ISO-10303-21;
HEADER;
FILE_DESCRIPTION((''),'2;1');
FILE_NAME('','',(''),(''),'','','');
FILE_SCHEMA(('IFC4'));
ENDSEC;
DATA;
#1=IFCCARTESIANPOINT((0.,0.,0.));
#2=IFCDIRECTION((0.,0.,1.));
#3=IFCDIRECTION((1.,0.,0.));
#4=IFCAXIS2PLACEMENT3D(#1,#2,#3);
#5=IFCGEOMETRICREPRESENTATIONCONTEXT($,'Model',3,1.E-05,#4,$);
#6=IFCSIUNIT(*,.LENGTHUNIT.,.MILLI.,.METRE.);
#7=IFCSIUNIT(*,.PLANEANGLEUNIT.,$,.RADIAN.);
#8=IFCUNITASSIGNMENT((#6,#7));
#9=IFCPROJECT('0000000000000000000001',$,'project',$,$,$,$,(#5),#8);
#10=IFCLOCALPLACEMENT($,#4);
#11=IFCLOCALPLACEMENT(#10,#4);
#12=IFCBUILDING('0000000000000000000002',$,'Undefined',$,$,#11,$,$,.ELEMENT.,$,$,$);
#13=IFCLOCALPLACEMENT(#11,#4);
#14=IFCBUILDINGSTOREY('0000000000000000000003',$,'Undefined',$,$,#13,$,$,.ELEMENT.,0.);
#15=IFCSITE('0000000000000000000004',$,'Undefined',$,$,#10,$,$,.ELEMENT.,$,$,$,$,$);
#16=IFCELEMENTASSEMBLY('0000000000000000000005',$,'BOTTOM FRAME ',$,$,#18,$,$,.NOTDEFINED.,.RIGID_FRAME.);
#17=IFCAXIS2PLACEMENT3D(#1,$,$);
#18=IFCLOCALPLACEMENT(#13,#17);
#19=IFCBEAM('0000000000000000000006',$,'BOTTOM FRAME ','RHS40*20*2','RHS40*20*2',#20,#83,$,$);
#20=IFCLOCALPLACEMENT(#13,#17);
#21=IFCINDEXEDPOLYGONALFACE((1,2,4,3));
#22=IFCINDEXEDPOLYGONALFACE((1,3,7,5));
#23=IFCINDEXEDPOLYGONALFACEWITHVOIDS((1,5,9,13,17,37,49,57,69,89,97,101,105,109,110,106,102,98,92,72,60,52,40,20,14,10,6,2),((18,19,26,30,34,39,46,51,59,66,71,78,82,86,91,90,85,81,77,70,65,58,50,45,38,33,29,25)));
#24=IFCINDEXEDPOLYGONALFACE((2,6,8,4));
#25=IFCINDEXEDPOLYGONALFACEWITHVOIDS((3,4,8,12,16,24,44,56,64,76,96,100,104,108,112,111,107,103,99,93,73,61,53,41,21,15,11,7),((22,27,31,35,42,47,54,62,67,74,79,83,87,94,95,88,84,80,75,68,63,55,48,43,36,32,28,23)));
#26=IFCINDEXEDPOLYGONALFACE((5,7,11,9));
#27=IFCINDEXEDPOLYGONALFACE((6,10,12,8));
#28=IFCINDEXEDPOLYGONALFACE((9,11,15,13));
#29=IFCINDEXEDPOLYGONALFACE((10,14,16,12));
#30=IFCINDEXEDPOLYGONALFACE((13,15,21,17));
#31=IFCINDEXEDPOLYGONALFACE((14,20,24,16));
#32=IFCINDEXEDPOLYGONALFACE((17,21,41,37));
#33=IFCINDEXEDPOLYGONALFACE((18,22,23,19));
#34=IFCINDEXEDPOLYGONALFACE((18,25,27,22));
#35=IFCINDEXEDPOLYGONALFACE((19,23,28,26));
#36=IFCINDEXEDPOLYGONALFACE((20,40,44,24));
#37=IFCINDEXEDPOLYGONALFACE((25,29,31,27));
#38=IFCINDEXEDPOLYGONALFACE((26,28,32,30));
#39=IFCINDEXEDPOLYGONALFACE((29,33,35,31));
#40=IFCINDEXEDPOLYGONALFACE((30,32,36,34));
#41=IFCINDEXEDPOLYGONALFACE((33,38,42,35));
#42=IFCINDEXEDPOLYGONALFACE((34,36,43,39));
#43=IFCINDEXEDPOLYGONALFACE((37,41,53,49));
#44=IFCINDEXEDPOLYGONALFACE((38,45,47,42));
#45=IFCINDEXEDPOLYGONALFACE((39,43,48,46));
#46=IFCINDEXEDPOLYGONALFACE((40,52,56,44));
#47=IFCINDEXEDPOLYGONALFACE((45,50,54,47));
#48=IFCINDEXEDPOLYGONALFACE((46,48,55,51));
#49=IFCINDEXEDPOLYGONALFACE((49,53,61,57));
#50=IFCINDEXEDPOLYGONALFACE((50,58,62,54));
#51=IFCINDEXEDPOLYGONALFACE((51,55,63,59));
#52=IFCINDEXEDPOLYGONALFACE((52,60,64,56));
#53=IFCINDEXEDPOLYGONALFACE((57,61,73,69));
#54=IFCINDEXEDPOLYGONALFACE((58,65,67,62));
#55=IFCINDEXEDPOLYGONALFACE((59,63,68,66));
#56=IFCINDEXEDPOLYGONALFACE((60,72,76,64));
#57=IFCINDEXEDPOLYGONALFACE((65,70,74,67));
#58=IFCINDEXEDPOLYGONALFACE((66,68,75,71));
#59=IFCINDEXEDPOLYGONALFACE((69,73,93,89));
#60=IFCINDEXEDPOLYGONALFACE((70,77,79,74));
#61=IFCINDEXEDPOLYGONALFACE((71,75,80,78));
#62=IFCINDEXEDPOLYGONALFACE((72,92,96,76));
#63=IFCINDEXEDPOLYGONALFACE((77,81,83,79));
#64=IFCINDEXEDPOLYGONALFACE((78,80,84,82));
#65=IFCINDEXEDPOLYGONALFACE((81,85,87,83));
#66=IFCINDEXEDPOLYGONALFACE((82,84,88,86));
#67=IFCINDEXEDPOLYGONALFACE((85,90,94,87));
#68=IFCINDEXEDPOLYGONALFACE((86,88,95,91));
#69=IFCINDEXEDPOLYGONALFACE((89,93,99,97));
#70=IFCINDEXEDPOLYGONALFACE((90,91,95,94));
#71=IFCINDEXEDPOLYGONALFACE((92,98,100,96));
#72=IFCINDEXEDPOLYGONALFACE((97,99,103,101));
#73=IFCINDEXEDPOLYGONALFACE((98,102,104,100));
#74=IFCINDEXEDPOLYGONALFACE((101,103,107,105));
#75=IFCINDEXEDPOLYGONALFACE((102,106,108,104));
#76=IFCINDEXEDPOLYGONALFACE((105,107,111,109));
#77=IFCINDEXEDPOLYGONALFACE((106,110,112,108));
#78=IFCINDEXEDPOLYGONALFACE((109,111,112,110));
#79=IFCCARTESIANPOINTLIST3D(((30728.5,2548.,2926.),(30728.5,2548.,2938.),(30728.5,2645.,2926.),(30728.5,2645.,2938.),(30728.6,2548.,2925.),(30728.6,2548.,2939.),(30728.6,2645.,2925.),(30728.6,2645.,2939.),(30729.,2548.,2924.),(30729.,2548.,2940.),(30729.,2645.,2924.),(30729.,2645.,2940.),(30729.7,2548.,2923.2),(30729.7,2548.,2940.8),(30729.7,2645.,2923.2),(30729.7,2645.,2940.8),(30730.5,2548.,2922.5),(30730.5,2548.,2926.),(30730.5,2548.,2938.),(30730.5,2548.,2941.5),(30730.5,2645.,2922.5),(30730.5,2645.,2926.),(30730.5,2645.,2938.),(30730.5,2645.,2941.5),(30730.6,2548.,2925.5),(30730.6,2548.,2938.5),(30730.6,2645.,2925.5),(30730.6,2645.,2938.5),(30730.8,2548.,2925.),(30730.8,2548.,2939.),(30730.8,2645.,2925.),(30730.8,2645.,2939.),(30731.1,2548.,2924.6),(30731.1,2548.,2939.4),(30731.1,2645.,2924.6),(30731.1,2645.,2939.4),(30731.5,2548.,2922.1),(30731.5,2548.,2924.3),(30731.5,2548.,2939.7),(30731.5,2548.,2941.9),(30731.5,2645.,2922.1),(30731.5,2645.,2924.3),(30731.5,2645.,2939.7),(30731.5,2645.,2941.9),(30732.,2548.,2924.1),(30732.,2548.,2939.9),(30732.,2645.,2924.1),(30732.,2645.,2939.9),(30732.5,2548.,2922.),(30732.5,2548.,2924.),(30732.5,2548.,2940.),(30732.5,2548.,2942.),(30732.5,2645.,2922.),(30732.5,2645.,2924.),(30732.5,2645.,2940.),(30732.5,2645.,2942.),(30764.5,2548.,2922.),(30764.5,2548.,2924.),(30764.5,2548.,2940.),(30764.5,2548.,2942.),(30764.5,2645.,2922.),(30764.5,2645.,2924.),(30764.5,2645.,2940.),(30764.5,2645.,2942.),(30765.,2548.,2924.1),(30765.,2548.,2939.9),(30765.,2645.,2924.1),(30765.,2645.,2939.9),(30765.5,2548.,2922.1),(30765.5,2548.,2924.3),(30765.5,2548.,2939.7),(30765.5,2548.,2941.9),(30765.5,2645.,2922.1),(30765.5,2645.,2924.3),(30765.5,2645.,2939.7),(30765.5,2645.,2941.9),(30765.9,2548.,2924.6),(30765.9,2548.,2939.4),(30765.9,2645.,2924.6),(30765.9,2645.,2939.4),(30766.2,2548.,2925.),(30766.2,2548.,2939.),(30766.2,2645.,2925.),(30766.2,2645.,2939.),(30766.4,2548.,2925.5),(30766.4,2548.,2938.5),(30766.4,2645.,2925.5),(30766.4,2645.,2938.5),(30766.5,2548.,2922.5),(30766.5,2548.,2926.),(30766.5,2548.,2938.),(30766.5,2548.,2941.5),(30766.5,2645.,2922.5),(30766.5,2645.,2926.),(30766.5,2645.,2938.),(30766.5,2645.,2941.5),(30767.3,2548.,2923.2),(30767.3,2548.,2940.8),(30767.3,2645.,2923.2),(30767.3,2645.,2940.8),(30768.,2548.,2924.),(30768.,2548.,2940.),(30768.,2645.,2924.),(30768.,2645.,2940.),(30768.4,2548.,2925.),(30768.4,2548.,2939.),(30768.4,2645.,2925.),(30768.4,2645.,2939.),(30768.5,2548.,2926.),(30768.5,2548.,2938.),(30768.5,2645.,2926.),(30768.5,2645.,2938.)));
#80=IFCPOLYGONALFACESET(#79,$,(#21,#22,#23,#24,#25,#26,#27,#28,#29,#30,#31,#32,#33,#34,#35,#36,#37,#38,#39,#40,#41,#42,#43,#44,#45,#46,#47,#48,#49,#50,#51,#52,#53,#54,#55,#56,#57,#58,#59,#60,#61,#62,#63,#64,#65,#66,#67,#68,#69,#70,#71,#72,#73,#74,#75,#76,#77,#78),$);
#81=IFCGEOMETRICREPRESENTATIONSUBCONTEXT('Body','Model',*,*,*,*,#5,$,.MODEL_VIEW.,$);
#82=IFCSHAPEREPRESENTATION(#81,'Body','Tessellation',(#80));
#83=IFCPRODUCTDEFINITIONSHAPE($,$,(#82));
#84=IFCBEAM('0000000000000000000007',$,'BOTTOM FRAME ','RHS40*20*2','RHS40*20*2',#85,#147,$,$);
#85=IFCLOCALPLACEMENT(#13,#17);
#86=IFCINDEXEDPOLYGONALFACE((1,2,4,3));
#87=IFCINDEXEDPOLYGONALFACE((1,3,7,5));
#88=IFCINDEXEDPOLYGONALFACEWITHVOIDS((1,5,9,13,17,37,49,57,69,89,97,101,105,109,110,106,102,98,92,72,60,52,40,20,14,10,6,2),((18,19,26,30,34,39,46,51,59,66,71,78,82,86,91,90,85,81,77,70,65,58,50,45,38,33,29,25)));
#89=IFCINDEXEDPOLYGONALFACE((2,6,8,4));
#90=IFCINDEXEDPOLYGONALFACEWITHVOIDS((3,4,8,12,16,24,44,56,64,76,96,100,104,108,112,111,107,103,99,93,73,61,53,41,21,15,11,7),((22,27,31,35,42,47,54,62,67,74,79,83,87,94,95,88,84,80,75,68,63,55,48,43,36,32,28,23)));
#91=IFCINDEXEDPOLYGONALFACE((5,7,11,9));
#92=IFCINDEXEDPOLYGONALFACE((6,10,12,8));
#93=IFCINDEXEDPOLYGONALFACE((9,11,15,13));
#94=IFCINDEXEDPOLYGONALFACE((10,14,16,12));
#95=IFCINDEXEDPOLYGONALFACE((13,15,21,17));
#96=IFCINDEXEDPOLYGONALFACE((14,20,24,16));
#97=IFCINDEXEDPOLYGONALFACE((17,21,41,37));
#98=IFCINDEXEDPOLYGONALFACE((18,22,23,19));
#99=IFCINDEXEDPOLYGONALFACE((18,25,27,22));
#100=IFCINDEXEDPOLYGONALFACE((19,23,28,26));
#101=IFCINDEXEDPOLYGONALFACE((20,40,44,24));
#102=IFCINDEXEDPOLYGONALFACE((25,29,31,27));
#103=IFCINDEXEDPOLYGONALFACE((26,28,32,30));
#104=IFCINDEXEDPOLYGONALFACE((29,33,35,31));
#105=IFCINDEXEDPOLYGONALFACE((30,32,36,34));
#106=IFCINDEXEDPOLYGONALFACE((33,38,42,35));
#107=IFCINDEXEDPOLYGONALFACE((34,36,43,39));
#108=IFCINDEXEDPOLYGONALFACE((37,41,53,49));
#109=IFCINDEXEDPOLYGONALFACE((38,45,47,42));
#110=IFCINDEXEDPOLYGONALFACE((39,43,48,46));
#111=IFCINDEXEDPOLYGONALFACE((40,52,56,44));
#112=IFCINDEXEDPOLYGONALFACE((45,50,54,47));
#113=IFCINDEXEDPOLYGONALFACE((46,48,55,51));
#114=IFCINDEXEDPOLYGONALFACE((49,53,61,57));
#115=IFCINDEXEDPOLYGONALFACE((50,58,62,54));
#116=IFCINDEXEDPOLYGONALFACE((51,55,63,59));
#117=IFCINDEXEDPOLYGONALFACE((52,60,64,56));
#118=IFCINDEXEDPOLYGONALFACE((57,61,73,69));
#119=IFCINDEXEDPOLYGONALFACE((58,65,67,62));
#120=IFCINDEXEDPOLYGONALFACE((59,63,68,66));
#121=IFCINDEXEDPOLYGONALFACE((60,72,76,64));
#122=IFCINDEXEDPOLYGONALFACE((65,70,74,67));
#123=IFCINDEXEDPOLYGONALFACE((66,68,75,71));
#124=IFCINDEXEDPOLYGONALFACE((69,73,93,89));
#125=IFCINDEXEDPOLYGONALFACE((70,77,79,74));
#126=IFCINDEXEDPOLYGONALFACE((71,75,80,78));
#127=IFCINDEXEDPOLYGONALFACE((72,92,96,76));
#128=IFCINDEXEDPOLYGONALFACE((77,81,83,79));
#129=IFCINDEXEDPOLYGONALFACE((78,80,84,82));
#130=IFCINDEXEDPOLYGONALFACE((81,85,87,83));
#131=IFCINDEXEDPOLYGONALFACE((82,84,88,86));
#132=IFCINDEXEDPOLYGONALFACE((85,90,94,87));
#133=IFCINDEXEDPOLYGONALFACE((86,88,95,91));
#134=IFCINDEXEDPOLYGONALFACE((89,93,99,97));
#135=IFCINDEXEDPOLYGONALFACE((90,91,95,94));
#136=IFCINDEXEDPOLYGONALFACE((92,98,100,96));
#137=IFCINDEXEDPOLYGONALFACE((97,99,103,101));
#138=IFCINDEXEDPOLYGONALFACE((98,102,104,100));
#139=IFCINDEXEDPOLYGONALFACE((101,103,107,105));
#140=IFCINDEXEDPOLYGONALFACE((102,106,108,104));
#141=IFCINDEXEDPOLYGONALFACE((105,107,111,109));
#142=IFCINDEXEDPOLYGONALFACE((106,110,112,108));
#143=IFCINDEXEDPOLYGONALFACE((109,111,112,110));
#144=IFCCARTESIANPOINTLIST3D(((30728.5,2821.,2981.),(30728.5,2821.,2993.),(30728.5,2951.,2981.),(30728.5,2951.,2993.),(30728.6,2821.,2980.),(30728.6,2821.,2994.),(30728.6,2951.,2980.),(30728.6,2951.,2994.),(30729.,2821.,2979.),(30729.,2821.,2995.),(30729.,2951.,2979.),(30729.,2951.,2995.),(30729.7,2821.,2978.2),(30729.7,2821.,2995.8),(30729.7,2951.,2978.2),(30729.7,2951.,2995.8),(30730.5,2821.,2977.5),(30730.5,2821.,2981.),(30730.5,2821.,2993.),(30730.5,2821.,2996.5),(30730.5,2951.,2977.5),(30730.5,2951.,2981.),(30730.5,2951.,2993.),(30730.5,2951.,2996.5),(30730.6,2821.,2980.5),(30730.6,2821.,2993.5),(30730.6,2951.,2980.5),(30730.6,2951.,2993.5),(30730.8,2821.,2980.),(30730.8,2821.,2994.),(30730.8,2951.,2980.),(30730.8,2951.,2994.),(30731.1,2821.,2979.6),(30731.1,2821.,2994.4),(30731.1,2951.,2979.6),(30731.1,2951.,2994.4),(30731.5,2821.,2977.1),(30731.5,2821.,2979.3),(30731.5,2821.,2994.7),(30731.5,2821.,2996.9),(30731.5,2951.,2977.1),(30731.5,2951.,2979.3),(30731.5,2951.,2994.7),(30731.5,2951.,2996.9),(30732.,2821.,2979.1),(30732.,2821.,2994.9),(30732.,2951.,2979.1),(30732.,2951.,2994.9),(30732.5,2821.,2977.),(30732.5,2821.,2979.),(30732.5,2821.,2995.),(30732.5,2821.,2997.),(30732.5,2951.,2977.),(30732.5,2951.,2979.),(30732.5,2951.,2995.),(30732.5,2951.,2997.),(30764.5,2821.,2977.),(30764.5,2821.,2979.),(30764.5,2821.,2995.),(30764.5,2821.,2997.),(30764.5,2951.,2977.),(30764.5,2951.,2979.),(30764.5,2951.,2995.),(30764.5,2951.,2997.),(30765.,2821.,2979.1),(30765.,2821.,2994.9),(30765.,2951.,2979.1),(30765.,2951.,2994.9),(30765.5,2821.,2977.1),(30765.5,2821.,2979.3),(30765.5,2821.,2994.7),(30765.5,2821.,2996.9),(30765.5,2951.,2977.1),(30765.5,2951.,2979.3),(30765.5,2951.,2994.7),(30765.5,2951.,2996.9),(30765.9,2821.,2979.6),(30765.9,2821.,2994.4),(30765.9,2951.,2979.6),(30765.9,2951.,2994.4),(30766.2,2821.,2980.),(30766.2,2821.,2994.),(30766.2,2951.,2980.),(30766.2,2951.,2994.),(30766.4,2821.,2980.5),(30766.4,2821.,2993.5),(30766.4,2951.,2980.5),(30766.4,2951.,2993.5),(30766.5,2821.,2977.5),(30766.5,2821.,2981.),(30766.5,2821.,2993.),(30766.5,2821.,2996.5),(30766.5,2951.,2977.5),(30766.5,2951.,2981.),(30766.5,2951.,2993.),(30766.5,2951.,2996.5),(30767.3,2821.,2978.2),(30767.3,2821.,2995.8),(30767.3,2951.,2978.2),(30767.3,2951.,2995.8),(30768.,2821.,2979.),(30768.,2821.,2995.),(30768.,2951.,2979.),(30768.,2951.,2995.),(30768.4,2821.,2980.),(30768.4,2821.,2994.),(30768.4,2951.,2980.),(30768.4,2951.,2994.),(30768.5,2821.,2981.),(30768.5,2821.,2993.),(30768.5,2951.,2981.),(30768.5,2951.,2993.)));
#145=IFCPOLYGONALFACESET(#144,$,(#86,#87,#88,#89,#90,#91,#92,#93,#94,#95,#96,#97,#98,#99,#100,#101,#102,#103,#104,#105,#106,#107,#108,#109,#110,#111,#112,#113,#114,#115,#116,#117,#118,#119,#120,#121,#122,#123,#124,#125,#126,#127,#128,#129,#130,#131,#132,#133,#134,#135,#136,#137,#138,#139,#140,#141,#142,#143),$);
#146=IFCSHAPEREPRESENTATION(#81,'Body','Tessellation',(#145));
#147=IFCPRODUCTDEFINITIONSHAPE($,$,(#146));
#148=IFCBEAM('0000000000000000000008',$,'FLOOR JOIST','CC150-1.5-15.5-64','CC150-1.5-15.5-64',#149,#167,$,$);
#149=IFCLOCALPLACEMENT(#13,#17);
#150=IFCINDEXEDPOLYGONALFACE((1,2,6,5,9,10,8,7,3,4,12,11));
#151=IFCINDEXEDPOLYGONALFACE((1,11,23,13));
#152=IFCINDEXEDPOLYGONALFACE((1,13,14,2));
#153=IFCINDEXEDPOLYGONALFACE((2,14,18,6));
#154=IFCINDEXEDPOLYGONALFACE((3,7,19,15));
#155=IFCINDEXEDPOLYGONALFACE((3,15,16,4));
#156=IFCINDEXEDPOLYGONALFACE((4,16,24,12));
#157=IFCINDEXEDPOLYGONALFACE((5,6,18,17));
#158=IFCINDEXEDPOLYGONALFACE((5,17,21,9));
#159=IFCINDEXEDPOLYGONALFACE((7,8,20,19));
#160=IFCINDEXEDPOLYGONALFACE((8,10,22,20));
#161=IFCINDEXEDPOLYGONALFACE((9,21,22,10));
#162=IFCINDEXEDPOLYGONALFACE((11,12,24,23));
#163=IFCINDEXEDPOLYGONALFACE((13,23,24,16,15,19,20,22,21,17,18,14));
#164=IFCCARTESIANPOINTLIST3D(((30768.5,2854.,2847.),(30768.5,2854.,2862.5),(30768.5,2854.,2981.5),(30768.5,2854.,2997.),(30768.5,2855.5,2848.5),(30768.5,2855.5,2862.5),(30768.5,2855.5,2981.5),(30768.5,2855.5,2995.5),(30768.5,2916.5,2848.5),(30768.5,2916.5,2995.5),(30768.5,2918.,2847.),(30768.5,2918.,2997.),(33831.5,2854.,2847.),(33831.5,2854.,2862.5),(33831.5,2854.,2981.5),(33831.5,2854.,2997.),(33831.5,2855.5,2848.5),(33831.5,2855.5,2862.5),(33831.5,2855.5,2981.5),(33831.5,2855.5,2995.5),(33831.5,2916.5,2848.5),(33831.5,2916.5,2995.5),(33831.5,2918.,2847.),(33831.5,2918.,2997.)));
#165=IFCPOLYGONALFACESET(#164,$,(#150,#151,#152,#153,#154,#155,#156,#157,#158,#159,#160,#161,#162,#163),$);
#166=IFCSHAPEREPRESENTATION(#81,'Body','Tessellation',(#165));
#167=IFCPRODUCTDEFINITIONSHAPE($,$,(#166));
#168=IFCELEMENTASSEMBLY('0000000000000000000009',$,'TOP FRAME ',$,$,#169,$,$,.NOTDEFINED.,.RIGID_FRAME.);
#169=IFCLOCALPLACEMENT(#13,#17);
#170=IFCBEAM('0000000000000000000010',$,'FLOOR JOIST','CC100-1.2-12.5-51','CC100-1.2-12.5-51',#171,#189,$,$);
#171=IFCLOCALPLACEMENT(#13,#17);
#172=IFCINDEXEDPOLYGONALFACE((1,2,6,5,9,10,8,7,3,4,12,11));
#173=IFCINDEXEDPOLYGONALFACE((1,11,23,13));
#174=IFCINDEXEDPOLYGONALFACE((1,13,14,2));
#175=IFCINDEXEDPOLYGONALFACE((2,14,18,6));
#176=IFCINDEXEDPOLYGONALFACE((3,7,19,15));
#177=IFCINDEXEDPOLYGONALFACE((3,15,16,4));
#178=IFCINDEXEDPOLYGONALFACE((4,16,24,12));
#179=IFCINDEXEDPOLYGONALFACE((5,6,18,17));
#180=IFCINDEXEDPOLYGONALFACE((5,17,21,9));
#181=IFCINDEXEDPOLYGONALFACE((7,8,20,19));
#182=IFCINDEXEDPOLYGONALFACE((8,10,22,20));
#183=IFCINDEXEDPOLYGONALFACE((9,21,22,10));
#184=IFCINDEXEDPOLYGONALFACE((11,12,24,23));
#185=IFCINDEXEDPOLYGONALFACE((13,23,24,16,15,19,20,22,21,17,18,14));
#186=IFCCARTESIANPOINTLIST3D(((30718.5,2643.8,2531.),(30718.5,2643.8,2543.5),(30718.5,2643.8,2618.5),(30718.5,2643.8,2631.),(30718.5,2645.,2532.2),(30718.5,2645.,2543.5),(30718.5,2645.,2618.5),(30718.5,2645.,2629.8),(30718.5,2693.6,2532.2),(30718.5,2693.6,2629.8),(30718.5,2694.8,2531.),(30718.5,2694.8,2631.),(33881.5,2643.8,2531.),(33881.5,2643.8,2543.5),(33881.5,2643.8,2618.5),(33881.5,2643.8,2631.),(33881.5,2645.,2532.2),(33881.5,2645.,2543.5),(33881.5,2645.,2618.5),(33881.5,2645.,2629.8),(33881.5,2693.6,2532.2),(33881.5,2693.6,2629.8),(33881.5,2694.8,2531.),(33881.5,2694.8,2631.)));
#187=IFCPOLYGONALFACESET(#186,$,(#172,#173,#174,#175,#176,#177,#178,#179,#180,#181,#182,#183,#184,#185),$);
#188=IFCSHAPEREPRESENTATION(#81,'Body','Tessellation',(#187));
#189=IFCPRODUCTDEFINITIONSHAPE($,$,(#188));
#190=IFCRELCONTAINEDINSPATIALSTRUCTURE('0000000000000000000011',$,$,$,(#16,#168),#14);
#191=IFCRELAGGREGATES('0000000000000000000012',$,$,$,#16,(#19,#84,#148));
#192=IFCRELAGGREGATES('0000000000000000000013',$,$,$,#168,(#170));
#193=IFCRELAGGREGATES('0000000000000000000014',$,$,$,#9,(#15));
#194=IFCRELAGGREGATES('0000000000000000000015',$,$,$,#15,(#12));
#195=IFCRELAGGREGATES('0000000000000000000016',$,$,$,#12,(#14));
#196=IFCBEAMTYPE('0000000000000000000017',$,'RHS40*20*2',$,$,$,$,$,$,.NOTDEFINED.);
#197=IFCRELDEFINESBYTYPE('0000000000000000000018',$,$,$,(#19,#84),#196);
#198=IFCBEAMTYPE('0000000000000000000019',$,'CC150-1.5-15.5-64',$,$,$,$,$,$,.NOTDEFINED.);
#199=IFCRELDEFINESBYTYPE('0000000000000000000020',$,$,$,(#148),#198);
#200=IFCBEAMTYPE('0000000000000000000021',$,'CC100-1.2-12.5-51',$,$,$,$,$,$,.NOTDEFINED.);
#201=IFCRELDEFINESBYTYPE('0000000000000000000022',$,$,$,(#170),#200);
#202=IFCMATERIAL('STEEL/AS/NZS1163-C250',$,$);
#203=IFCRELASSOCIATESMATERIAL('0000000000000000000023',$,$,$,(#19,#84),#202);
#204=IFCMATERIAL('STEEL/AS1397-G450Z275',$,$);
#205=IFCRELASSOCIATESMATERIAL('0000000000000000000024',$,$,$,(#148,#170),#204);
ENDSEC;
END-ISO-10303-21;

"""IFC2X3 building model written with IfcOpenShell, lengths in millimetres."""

from ifc_helpers import new_model, si_unit, frame, origin_with_axes, origin_2d_with_axis, place, context, subcontext, project, spatial, hollow_rectangle, c_section, extrude, material, type_object, element, aggregate, save


model = new_model("IFC2X3")

# Units and contexts
model_context = context("Model", 3, precision=1e-05, world=origin_with_axes())
body_context = subcontext(model_context, "Body", "Model", "MODEL_VIEW")
ifc_project = project(units=[si_unit("LENGTHUNIT", "METRE", prefix="MILLI"), si_unit("PLANEANGLEUNIT", "RADIAN")], contexts=[model_context])

# Site, building, storey
site_placement = place(None, origin_with_axes())
site = spatial("IfcSite", under=ifc_project, at=site_placement, Name="Undefined", CompositionType="ELEMENT")
building_placement = place(site_placement, origin_with_axes())
building = spatial("IfcBuilding", under=site, at=building_placement, Name="Undefined", CompositionType="ELEMENT")
storey_placement = place(building_placement, origin_with_axes())
storey = spatial("IfcBuildingStorey", under=building, at=storey_placement, Name="Undefined", CompositionType="ELEMENT", Elevation=0.0)

# Element assemblies, beams
assembly_1_placement = place(storey_placement, origin_with_axes())
assembly_1 = element("IfcElementAssembly", 1, at=assembly_1_placement, inside=storey, Name="BOTTOM FRAME ", AssemblyPlace="NOTDEFINED", PredefinedType="RIGID_FRAME")
ifc_material_1 = material(Name="STEEL/AS1397-G450Z275")
ifc_material_2 = material(Name="STEEL/AS/NZS1163-C250")
beam_type_1 = type_object("IfcBeamType", Name="RHS40*20*2", PredefinedType="NOTDEFINED")
beam_1_placement = place(assembly_1_placement, frame((30748.5, 2645.0, 2932.0), z_axis=(1.0, 0.0, 0.0), x_axis=(0.0, -1.0, 0.0)))
beam_1 = element("IfcBeam", 2, at=beam_1_placement, type_object=beam_type_1, material=ifc_material_2, Name="BOTTOM FRAME ", Description="RHS40*20*2", ObjectType="RHS40*20*2", context=body_context, shape_type="SweptSolid", body=[
    extrude(hollow_rectangle(XDim=20.0, YDim=40.0, WallThickness=2.0, InnerFilletRadius=2.0, OuterFilletRadius=4.0, at=origin_2d_with_axis()), frame((97.0, 0.0, 0.0), z_axis=(-1.0, 0.0, 0.0), x_axis=(0.0, -1.0, 0.0)), (0.0, 0.0, 1.0), 97.0),
])
beam_2_placement = place(assembly_1_placement, frame((30748.5, 2951.0, 2987.0), z_axis=(1.0, 0.0, 0.0), x_axis=(0.0, -1.0, 0.0)))
beam_2 = element("IfcBeam", 3, at=beam_2_placement, type_object=beam_type_1, material=ifc_material_2, Name="BOTTOM FRAME ", Description="RHS40*20*2", ObjectType="RHS40*20*2", context=body_context, shape_type="SweptSolid", body=[
    extrude(hollow_rectangle(XDim=20.0, YDim=40.0, WallThickness=2.0, InnerFilletRadius=2.0, OuterFilletRadius=4.0, at=origin_2d_with_axis()), frame((130.0, 0.0, 0.0), z_axis=(-1.0, 0.0, 0.0), x_axis=(0.0, -1.0, 0.0)), (0.0, 0.0, 1.0), 130.0),
])
beam_type_2 = type_object("IfcBeamType", Name="CC150-1.5-15.5-64", PredefinedType="NOTDEFINED")
beam_3_placement = place(assembly_1_placement, frame((30768.5, 2886.0, 2922.0), z_axis=(0.0, 0.0, 1.0), x_axis=(1.0, 0.0, 0.0)))
beam_3 = element("IfcBeam", 4, at=beam_3_placement, type_object=beam_type_2, material=ifc_material_1, Name="FLOOR JOIST", Description="CC150-1.5-15.5-64", ObjectType="CC150-1.5-15.5-64", context=body_context, shape_type="SweptSolid", body=[
    extrude(c_section(Depth=150.0, Width=64.0, WallThickness=1.5, Girth=15.5, at=origin_2d_with_axis()), frame((3063.0, 0.0, 0.0), z_axis=(-1.0, 0.0, 0.0), x_axis=(0.0, -1.0, 0.0)), (0.0, 0.0, 1.0), 3063.0),
])
aggregate(assembly_1, [beam_1, beam_2, beam_3])
assembly_2_placement = place(storey_placement, origin_with_axes())
assembly_2 = element("IfcElementAssembly", 5, at=assembly_2_placement, inside=storey, Name="TOP FRAME ", AssemblyPlace="NOTDEFINED", PredefinedType="RIGID_FRAME")
beam_type_3 = type_object("IfcBeamType", Name="CC100-1.2-12.5-51", PredefinedType="NOTDEFINED")
beam_4_placement = place(assembly_2_placement, frame((30718.5, 2669.3, 2581.0), z_axis=(0.0, 0.0, 1.0), x_axis=(1.0, 0.0, 0.0)))
beam_4 = element("IfcBeam", 6, at=beam_4_placement, type_object=beam_type_3, material=ifc_material_1, Name="FLOOR JOIST", Description="CC100-1.2-12.5-51", ObjectType="CC100-1.2-12.5-51", context=body_context, shape_type="SweptSolid", body=[
    extrude(c_section(Depth=100.0, Width=51.0, WallThickness=1.2, Girth=12.5, at=origin_2d_with_axis()), frame((3163.0, 0.0, 0.0), z_axis=(-1.0, 0.0, 0.0), x_axis=(0.0, -1.0, 0.0)), (0.0, 0.0, 1.0), 3163.0),
])
aggregate(assembly_2, [beam_4])

save(model, "model.ifc")
